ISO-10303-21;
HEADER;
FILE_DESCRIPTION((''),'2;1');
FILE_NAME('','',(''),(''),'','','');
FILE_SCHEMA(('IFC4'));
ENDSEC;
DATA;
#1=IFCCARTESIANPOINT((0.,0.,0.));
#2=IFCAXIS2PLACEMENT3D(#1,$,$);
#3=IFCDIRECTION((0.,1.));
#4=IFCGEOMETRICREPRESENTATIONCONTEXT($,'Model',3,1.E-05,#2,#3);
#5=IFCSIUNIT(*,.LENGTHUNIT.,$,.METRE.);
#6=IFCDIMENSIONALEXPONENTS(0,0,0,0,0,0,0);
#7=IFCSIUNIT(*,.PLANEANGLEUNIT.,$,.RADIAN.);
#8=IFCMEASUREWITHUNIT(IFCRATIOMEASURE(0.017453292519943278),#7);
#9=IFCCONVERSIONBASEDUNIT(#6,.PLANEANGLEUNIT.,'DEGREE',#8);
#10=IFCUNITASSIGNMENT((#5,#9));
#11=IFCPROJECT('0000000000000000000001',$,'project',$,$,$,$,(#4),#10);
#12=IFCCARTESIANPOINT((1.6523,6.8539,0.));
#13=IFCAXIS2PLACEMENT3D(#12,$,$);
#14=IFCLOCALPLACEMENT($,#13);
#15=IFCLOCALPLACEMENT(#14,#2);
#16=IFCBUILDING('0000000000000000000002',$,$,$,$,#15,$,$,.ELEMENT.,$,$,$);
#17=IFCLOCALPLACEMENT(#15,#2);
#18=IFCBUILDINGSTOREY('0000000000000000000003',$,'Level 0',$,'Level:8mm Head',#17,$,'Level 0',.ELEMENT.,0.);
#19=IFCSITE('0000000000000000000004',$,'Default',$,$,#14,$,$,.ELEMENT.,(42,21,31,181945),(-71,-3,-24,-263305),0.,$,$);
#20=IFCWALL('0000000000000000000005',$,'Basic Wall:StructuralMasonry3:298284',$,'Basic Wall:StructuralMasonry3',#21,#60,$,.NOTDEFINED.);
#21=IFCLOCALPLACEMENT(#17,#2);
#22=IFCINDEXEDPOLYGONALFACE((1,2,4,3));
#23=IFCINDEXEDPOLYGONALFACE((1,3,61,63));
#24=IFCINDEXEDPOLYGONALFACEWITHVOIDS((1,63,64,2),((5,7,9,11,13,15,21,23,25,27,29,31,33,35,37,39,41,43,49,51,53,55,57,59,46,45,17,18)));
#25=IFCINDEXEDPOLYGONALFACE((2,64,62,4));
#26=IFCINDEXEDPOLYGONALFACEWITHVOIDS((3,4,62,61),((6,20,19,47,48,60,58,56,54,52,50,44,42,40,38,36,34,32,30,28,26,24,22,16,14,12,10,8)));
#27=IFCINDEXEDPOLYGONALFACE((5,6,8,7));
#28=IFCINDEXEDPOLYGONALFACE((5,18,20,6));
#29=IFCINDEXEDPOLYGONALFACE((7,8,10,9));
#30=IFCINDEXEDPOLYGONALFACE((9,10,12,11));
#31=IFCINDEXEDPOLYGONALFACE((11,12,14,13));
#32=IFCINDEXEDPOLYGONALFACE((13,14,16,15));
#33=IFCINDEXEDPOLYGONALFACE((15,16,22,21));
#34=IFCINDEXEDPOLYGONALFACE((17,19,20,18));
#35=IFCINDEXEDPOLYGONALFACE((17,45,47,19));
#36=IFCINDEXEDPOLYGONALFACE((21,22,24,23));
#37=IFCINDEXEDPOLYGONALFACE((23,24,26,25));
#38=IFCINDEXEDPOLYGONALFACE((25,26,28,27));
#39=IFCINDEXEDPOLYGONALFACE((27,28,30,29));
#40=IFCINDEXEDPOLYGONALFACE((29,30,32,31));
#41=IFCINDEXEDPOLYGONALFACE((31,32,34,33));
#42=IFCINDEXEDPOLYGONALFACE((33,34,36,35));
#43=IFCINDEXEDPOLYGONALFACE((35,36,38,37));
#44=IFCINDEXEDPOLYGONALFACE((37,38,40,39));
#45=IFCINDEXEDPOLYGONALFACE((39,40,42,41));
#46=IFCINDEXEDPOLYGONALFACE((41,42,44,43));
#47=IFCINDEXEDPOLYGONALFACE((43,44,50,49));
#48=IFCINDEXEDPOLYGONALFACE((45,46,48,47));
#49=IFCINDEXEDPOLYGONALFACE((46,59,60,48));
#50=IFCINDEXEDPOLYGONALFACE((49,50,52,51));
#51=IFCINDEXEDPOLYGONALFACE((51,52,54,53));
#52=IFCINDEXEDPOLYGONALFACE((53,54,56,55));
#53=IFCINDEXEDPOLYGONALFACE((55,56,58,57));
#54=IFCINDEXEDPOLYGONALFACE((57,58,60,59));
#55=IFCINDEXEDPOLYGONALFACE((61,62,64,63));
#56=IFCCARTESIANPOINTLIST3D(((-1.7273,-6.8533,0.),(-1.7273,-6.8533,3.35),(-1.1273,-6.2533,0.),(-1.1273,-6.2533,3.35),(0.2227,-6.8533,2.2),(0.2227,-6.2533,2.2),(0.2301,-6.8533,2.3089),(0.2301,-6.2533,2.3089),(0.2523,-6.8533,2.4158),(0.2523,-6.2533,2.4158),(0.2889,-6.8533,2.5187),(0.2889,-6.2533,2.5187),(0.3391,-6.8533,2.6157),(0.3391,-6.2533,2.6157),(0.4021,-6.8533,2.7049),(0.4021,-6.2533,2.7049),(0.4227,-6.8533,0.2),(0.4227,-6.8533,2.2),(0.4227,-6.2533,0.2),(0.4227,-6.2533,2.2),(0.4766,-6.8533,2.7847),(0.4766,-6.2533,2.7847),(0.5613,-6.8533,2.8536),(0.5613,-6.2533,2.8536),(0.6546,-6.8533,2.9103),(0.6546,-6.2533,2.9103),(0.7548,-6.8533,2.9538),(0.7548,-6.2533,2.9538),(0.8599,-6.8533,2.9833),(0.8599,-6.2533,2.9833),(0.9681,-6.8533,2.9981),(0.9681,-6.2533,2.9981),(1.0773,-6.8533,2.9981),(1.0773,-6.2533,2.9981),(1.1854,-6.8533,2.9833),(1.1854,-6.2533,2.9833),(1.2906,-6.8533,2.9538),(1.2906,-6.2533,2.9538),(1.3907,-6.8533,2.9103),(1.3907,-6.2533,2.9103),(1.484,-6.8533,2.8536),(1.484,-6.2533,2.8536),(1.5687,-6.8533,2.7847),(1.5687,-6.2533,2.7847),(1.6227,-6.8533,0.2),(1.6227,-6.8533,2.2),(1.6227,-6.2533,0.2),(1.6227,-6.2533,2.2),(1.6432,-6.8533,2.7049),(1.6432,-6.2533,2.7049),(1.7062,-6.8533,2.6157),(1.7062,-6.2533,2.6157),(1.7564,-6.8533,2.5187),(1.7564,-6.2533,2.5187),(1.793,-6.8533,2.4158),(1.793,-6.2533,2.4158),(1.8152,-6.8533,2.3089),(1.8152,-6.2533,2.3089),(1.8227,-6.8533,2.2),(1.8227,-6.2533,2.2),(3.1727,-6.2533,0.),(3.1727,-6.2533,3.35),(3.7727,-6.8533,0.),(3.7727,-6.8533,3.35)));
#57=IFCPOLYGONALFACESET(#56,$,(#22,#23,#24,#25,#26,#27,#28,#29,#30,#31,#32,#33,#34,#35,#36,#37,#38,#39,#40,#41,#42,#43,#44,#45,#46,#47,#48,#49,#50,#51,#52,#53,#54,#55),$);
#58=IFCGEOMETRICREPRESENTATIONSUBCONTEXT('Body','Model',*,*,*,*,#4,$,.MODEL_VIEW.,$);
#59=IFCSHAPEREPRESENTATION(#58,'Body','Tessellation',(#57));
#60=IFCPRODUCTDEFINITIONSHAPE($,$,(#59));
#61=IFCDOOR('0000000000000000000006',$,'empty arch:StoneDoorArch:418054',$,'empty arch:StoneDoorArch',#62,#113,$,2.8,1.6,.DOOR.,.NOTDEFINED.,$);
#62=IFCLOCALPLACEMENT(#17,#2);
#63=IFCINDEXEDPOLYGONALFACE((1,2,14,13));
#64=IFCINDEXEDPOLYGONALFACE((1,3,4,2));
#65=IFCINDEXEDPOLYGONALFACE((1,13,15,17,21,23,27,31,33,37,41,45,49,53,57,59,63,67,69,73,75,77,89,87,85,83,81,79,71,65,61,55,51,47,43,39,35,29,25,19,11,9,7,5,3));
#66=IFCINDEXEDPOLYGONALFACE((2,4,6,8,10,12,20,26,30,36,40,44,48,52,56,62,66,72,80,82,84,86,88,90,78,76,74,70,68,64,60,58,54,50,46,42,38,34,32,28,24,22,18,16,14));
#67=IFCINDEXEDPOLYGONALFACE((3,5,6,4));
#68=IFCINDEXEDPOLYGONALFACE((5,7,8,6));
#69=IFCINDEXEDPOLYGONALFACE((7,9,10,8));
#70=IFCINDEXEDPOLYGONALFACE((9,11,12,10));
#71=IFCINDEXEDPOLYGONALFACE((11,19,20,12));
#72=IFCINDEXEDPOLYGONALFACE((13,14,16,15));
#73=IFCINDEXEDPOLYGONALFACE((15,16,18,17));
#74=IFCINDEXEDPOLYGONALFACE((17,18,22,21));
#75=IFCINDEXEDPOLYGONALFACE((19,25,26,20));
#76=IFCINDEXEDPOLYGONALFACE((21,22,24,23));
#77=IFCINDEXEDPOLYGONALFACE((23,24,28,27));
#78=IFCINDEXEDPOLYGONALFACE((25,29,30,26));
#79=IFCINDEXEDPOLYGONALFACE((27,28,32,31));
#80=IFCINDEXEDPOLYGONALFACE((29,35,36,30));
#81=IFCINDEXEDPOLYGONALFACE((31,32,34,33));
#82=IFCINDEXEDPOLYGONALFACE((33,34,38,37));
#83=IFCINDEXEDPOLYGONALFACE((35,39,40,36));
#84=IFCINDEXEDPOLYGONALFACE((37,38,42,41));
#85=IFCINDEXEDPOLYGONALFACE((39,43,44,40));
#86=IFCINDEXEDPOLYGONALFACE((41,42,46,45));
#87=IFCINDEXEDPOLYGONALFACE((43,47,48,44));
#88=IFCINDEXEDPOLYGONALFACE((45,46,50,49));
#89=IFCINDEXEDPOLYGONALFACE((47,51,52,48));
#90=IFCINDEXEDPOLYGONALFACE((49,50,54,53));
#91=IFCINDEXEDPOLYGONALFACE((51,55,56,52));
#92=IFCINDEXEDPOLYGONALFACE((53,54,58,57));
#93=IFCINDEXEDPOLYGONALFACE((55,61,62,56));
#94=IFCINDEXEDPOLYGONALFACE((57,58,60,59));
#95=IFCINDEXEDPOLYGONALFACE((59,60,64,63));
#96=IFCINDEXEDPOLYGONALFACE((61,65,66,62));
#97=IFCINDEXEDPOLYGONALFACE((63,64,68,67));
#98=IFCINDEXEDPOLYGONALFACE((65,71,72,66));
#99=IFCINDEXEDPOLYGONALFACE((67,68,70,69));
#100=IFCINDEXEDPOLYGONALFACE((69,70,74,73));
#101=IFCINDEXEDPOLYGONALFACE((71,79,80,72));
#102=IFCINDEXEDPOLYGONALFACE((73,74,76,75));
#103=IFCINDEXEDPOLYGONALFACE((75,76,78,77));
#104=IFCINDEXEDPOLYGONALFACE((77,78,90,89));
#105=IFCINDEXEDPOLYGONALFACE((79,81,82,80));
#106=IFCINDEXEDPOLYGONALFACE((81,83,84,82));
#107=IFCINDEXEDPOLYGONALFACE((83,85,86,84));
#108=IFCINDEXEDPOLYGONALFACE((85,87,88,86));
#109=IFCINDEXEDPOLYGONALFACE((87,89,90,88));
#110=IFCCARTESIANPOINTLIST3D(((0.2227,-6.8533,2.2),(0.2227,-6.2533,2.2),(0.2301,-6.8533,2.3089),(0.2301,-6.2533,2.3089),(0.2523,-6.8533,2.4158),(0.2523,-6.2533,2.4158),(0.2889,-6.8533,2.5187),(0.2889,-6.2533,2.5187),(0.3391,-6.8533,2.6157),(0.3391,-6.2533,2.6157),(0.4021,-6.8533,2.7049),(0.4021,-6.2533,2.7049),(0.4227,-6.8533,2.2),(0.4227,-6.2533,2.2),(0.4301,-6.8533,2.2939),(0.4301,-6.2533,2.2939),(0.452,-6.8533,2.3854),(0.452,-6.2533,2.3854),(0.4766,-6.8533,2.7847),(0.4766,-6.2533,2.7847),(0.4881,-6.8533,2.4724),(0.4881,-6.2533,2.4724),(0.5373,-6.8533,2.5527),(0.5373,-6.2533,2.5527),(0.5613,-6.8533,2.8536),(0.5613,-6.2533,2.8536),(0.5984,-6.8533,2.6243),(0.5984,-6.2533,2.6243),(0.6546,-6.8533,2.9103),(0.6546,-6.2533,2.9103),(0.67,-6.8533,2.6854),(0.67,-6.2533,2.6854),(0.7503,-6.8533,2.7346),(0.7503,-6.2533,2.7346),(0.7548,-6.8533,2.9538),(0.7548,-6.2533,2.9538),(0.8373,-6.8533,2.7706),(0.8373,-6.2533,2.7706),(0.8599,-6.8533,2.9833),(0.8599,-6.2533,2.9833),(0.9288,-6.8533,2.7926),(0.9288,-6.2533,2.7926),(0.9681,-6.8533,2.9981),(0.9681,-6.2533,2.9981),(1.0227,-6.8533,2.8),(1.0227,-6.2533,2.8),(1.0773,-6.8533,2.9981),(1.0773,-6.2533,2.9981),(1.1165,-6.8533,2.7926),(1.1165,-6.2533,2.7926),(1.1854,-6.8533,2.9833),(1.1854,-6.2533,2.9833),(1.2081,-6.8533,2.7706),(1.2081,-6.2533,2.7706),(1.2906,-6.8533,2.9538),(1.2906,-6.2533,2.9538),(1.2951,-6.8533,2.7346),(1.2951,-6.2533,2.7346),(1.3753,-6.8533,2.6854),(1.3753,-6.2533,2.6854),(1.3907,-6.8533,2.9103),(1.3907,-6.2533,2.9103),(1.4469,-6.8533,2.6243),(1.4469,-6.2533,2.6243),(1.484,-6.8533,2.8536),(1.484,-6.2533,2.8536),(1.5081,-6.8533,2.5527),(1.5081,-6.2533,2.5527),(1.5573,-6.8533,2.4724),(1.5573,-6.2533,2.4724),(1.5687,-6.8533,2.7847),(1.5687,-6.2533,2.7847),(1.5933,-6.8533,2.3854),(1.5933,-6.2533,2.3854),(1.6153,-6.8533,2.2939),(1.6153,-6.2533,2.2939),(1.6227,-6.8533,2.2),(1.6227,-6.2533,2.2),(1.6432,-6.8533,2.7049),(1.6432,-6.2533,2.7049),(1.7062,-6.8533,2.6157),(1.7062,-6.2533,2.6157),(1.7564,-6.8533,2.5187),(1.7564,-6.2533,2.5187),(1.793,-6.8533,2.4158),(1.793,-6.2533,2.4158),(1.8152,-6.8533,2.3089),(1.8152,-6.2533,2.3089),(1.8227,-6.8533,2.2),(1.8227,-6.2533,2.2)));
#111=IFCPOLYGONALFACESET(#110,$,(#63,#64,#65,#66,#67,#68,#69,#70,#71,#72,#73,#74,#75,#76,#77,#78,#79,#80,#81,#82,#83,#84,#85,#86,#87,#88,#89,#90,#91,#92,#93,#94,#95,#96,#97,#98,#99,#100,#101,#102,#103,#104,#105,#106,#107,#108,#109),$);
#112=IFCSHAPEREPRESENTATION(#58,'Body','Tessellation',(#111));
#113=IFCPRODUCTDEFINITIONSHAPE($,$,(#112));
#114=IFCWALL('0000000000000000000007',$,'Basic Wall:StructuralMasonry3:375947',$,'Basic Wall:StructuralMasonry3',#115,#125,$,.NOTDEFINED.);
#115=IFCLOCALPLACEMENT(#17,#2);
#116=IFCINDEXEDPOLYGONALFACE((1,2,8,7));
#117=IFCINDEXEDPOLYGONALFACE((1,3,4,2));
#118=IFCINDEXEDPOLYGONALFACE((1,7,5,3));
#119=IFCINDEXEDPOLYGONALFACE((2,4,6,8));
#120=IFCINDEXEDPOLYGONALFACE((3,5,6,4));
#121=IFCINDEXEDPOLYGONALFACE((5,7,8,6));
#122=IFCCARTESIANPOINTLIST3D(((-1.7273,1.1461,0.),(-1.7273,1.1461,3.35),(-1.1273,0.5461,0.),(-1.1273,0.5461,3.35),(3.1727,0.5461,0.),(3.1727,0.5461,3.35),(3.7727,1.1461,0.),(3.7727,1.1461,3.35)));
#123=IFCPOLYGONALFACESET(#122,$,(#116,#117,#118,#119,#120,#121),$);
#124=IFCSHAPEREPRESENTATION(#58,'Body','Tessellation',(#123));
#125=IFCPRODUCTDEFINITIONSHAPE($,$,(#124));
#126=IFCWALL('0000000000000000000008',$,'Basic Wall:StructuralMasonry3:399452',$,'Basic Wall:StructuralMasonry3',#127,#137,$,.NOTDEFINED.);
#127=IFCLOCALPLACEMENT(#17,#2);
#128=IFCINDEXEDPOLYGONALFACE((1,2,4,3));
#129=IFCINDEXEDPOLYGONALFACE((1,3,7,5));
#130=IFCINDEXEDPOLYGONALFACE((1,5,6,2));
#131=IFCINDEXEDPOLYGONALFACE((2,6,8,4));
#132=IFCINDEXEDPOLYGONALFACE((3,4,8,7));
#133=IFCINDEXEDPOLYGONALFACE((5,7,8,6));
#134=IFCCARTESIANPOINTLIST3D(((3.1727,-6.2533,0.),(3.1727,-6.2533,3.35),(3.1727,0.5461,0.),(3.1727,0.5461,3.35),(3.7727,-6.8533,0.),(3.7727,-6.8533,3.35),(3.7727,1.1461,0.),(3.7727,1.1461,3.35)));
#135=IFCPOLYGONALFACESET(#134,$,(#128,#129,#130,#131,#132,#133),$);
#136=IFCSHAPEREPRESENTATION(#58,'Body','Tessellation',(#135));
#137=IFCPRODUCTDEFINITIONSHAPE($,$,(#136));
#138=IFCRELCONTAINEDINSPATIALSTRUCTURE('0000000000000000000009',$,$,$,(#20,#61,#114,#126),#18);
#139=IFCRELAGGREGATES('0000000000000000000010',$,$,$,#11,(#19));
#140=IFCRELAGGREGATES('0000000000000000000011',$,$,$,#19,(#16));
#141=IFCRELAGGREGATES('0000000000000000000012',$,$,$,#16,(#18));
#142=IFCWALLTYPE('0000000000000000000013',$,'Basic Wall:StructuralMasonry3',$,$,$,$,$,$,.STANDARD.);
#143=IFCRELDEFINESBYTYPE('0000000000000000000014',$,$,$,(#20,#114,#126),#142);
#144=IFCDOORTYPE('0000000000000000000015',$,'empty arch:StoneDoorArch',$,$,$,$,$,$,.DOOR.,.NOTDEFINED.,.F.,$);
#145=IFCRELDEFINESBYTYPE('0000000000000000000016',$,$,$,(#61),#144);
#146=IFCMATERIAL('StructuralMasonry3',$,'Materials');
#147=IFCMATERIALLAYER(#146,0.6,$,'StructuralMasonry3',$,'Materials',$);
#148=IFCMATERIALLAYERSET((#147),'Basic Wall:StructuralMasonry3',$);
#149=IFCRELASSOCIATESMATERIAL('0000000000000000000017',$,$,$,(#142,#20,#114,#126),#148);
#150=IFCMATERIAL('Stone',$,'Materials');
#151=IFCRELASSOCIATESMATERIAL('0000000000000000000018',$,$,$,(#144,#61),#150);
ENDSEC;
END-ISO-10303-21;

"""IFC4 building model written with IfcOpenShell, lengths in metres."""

from ifc_helpers import new_model, entity, si_unit, converted_unit, direction, frame, frame_2d, origin, place, context, subcontext, project, spatial, polyline, circle_curve, parameter, trimmed, segment, composite_curve, outline, extrude, source, transform, mapped, material, layer, layer_set, layer_usage, type_object, type_shapes, element, fill, save


model = new_model("IFC4")

# Units and contexts
model_context = context("Model", 3, precision=1e-05, world=origin(), true_north=direction((0.0, 1.0)))
body_context = subcontext(model_context, "Body", "Model", "MODEL_VIEW")
ifc_project = project(units=[si_unit("LENGTHUNIT", "METRE"), converted_unit("PLANEANGLEUNIT", "DEGREE", entity("IfcRatioMeasure", 0.017453292519943278), si_unit("PLANEANGLEUNIT", "RADIAN"), dimensions=[0, 0, 0, 0, 0, 0, 0])], contexts=[model_context])

# Site, building, storey
site_placement = place(None, frame((1.6523, 6.8539, 0.0)))
site = spatial("IfcSite", under=ifc_project, at=site_placement, Name="Default", CompositionType="ELEMENT", RefLatitude=(42, 21, 31, 181945), RefLongitude=(-71, -3, -24, -263305), RefElevation=0.0)
building_placement = place(site_placement, origin())
building = spatial("IfcBuilding", under=site, at=building_placement, CompositionType="ELEMENT")
storey_placement = place(building_placement, origin())
storey = spatial("IfcBuildingStorey", under=building, at=storey_placement, Name="Level 0", ObjectType="Level:8mm Head", LongName="Level 0", CompositionType="ELEMENT", Elevation=0.0)

# Shared definitions
ifc_material_1 = material(Name="StructuralMasonry3", Category="Materials")
ifc_layer = layer(ifc_material_1, 0.6, Name="StructuralMasonry3", Category="Materials")
ifc_layer_set = layer_set([ifc_layer], Name="Basic Wall:StructuralMasonry3")
ifc_layer_usage = layer_usage(ifc_layer_set, "AXIS2", "NEGATIVE", 0.3)
wall_type = type_object("IfcWallType", Name="Basic Wall:StructuralMasonry3", PredefinedType="STANDARD", material=ifc_layer_set)
ifc_material_2 = material(Name="Stone", Category="Materials")

# Wall, opening, door
wall_1_placement = place(storey_placement, frame((3.7727, -6.5533, 0.0), z_axis=(0.0, 0.0, 1.0), x_axis=(-1.0, 0.0, 0.0)))
wall_1 = element("IfcWall", 1, at=wall_1_placement, inside=storey, type_object=wall_type, material=ifc_layer_usage, Name="Basic Wall:StructuralMasonry3:298284", ObjectType="Basic Wall:StructuralMasonry3", PredefinedType="NOTDEFINED", context=body_context, shape_type="SweptSolid", body=[
    extrude(outline(polyline([(4.9, -0.3), (5.5, 0.3), (0.0, 0.3), (0.6, -0.3), (4.9, -0.3)])), origin(), (0.0, 0.0, 1.0), 3.35),
])
opening_1_placement = place(wall_1_placement, frame((3.55, 0.3, 0.2)))
opening_1 = element("IfcOpeningElement", 2, at=opening_1_placement, cuts=wall_1, PredefinedType="OPENING", context=body_context, shape_type="SweptSolid", body=[
    extrude(outline(composite_curve([segment(polyline([(0.0, 1.4), (0.0, 0.2)]), True, "CONTINUOUS"), segment(polyline([(0.0, 0.2), (2.0, 0.2)]), True, "CONTINUOUS"), segment(polyline([(2.0, 0.2), (2.0, 0.0)]), True, "CONTINUOUS"), segment(trimmed(circle_curve(frame_2d((2.0, 0.8), x_axis=(0.0, 1.0)), 0.8), [parameter(180.0)], [parameter(0.0)], True, "PARAMETER"), True, "CONTINUOUS"), segment(polyline([(2.0, 1.6), (2.0, 1.4)]), True, "CONTINUOUS"), segment(polyline([(2.0, 1.4), (0.0, 1.4)]), True, "CONTINUOUS")], self_intersect=False)), frame((0.0, 0.0, 0.0), z_axis=(0.0, -1.0, 0.0), x_axis=(0.0, 0.0, 1.0)), (0.0, 0.0, 1.0), 0.6),
])
door_type_1 = type_object("IfcDoorType", Name="empty arch:StoneDoorArch", OperationType="NOTDEFINED", ParameterTakesPrecedence=False, PredefinedType="DOOR", material=ifc_material_2)
shared_shape_1 = source(origin(), body_context, "Body", "SweptSolid", [
    extrude(outline(composite_curve([segment(trimmed(circle_curve(frame_2d((0.0, 0.0), x_axis=(-1.0, 0.0)), 0.6), [parameter(0.0)], [parameter(180.0)], True, "PARAMETER"), False, "CONTINUOUS"), segment(polyline([(-0.6, 0.0), (-0.8, 0.0)]), True, "CONTINUOUS"), segment(trimmed(circle_curve(frame_2d((0.0, 0.0), x_axis=(-1.0, 0.0)), 0.8), [parameter(0.0)], [parameter(180.0)], True, "PARAMETER"), True, "CONTINUOUS"), segment(polyline([(0.8, 0.0), (0.6, 0.0)]), True, "CONTINUOUS")], self_intersect=False)), frame((0.8, 0.0, 2.0), z_axis=(0.0, -1.0, 0.0), x_axis=(-1.0, 0.0, 0.0)), (0.0, 0.0, -1.0), 0.6),
])
type_shapes(door_type_1, [shared_shape_1])
door_1_placement = place(opening_1_placement, frame((0.0, 0.0, 0.0), z_axis=(0.0, 0.0, 1.0), x_axis=(-1.0, 0.0, 0.0)))
door_1 = element("IfcDoor", 3, at=door_1_placement, inside=storey, type_object=door_type_1, material=ifc_material_2, Name="empty arch:StoneDoorArch:418054", ObjectType="empty arch:StoneDoorArch", OperationType="NOTDEFINED", OverallHeight=2.8, OverallWidth=1.6, PredefinedType="DOOR", context=body_context, shape_type="MappedRepresentation", body=[
    mapped(shared_shape_1, transform((0.0, 0.0, 0.0), scale=1.0)),
])
fill(opening_1, door_1)

# Walls
wall_2_placement = place(storey_placement, frame((-1.7273, 0.8461, 0.0)))
element("IfcWall", 4, at=wall_2_placement, inside=storey, type_object=wall_type, material=ifc_layer_usage, Name="Basic Wall:StructuralMasonry3:375947", ObjectType="Basic Wall:StructuralMasonry3", PredefinedType="NOTDEFINED", context=body_context, shape_type="SweptSolid", body=[
    extrude(outline(polyline([(4.9, -0.3), (5.5, 0.3), (0.0, 0.3), (0.6, -0.3), (4.9, -0.3)])), origin(), (0.0, 0.0, 1.0), 3.35),
])
wall_3_placement = place(storey_placement, frame((3.4727, 1.1461, 0.0), z_axis=(0.0, 0.0, 1.0), x_axis=(0.0, -1.0, 0.0)))
element("IfcWall", 5, at=wall_3_placement, inside=storey, type_object=wall_type, material=ifc_layer_usage, Name="Basic Wall:StructuralMasonry3:399452", ObjectType="Basic Wall:StructuralMasonry3", PredefinedType="NOTDEFINED", context=body_context, shape_type="SweptSolid", body=[
    extrude(outline(polyline([(7.3994, -0.3), (7.9994, 0.3), (0.0, 0.3), (0.6, -0.3), (7.3994, -0.3)])), origin(), (0.0, 0.0, 1.0), 3.35),
])

save(model, "model.ifc")
